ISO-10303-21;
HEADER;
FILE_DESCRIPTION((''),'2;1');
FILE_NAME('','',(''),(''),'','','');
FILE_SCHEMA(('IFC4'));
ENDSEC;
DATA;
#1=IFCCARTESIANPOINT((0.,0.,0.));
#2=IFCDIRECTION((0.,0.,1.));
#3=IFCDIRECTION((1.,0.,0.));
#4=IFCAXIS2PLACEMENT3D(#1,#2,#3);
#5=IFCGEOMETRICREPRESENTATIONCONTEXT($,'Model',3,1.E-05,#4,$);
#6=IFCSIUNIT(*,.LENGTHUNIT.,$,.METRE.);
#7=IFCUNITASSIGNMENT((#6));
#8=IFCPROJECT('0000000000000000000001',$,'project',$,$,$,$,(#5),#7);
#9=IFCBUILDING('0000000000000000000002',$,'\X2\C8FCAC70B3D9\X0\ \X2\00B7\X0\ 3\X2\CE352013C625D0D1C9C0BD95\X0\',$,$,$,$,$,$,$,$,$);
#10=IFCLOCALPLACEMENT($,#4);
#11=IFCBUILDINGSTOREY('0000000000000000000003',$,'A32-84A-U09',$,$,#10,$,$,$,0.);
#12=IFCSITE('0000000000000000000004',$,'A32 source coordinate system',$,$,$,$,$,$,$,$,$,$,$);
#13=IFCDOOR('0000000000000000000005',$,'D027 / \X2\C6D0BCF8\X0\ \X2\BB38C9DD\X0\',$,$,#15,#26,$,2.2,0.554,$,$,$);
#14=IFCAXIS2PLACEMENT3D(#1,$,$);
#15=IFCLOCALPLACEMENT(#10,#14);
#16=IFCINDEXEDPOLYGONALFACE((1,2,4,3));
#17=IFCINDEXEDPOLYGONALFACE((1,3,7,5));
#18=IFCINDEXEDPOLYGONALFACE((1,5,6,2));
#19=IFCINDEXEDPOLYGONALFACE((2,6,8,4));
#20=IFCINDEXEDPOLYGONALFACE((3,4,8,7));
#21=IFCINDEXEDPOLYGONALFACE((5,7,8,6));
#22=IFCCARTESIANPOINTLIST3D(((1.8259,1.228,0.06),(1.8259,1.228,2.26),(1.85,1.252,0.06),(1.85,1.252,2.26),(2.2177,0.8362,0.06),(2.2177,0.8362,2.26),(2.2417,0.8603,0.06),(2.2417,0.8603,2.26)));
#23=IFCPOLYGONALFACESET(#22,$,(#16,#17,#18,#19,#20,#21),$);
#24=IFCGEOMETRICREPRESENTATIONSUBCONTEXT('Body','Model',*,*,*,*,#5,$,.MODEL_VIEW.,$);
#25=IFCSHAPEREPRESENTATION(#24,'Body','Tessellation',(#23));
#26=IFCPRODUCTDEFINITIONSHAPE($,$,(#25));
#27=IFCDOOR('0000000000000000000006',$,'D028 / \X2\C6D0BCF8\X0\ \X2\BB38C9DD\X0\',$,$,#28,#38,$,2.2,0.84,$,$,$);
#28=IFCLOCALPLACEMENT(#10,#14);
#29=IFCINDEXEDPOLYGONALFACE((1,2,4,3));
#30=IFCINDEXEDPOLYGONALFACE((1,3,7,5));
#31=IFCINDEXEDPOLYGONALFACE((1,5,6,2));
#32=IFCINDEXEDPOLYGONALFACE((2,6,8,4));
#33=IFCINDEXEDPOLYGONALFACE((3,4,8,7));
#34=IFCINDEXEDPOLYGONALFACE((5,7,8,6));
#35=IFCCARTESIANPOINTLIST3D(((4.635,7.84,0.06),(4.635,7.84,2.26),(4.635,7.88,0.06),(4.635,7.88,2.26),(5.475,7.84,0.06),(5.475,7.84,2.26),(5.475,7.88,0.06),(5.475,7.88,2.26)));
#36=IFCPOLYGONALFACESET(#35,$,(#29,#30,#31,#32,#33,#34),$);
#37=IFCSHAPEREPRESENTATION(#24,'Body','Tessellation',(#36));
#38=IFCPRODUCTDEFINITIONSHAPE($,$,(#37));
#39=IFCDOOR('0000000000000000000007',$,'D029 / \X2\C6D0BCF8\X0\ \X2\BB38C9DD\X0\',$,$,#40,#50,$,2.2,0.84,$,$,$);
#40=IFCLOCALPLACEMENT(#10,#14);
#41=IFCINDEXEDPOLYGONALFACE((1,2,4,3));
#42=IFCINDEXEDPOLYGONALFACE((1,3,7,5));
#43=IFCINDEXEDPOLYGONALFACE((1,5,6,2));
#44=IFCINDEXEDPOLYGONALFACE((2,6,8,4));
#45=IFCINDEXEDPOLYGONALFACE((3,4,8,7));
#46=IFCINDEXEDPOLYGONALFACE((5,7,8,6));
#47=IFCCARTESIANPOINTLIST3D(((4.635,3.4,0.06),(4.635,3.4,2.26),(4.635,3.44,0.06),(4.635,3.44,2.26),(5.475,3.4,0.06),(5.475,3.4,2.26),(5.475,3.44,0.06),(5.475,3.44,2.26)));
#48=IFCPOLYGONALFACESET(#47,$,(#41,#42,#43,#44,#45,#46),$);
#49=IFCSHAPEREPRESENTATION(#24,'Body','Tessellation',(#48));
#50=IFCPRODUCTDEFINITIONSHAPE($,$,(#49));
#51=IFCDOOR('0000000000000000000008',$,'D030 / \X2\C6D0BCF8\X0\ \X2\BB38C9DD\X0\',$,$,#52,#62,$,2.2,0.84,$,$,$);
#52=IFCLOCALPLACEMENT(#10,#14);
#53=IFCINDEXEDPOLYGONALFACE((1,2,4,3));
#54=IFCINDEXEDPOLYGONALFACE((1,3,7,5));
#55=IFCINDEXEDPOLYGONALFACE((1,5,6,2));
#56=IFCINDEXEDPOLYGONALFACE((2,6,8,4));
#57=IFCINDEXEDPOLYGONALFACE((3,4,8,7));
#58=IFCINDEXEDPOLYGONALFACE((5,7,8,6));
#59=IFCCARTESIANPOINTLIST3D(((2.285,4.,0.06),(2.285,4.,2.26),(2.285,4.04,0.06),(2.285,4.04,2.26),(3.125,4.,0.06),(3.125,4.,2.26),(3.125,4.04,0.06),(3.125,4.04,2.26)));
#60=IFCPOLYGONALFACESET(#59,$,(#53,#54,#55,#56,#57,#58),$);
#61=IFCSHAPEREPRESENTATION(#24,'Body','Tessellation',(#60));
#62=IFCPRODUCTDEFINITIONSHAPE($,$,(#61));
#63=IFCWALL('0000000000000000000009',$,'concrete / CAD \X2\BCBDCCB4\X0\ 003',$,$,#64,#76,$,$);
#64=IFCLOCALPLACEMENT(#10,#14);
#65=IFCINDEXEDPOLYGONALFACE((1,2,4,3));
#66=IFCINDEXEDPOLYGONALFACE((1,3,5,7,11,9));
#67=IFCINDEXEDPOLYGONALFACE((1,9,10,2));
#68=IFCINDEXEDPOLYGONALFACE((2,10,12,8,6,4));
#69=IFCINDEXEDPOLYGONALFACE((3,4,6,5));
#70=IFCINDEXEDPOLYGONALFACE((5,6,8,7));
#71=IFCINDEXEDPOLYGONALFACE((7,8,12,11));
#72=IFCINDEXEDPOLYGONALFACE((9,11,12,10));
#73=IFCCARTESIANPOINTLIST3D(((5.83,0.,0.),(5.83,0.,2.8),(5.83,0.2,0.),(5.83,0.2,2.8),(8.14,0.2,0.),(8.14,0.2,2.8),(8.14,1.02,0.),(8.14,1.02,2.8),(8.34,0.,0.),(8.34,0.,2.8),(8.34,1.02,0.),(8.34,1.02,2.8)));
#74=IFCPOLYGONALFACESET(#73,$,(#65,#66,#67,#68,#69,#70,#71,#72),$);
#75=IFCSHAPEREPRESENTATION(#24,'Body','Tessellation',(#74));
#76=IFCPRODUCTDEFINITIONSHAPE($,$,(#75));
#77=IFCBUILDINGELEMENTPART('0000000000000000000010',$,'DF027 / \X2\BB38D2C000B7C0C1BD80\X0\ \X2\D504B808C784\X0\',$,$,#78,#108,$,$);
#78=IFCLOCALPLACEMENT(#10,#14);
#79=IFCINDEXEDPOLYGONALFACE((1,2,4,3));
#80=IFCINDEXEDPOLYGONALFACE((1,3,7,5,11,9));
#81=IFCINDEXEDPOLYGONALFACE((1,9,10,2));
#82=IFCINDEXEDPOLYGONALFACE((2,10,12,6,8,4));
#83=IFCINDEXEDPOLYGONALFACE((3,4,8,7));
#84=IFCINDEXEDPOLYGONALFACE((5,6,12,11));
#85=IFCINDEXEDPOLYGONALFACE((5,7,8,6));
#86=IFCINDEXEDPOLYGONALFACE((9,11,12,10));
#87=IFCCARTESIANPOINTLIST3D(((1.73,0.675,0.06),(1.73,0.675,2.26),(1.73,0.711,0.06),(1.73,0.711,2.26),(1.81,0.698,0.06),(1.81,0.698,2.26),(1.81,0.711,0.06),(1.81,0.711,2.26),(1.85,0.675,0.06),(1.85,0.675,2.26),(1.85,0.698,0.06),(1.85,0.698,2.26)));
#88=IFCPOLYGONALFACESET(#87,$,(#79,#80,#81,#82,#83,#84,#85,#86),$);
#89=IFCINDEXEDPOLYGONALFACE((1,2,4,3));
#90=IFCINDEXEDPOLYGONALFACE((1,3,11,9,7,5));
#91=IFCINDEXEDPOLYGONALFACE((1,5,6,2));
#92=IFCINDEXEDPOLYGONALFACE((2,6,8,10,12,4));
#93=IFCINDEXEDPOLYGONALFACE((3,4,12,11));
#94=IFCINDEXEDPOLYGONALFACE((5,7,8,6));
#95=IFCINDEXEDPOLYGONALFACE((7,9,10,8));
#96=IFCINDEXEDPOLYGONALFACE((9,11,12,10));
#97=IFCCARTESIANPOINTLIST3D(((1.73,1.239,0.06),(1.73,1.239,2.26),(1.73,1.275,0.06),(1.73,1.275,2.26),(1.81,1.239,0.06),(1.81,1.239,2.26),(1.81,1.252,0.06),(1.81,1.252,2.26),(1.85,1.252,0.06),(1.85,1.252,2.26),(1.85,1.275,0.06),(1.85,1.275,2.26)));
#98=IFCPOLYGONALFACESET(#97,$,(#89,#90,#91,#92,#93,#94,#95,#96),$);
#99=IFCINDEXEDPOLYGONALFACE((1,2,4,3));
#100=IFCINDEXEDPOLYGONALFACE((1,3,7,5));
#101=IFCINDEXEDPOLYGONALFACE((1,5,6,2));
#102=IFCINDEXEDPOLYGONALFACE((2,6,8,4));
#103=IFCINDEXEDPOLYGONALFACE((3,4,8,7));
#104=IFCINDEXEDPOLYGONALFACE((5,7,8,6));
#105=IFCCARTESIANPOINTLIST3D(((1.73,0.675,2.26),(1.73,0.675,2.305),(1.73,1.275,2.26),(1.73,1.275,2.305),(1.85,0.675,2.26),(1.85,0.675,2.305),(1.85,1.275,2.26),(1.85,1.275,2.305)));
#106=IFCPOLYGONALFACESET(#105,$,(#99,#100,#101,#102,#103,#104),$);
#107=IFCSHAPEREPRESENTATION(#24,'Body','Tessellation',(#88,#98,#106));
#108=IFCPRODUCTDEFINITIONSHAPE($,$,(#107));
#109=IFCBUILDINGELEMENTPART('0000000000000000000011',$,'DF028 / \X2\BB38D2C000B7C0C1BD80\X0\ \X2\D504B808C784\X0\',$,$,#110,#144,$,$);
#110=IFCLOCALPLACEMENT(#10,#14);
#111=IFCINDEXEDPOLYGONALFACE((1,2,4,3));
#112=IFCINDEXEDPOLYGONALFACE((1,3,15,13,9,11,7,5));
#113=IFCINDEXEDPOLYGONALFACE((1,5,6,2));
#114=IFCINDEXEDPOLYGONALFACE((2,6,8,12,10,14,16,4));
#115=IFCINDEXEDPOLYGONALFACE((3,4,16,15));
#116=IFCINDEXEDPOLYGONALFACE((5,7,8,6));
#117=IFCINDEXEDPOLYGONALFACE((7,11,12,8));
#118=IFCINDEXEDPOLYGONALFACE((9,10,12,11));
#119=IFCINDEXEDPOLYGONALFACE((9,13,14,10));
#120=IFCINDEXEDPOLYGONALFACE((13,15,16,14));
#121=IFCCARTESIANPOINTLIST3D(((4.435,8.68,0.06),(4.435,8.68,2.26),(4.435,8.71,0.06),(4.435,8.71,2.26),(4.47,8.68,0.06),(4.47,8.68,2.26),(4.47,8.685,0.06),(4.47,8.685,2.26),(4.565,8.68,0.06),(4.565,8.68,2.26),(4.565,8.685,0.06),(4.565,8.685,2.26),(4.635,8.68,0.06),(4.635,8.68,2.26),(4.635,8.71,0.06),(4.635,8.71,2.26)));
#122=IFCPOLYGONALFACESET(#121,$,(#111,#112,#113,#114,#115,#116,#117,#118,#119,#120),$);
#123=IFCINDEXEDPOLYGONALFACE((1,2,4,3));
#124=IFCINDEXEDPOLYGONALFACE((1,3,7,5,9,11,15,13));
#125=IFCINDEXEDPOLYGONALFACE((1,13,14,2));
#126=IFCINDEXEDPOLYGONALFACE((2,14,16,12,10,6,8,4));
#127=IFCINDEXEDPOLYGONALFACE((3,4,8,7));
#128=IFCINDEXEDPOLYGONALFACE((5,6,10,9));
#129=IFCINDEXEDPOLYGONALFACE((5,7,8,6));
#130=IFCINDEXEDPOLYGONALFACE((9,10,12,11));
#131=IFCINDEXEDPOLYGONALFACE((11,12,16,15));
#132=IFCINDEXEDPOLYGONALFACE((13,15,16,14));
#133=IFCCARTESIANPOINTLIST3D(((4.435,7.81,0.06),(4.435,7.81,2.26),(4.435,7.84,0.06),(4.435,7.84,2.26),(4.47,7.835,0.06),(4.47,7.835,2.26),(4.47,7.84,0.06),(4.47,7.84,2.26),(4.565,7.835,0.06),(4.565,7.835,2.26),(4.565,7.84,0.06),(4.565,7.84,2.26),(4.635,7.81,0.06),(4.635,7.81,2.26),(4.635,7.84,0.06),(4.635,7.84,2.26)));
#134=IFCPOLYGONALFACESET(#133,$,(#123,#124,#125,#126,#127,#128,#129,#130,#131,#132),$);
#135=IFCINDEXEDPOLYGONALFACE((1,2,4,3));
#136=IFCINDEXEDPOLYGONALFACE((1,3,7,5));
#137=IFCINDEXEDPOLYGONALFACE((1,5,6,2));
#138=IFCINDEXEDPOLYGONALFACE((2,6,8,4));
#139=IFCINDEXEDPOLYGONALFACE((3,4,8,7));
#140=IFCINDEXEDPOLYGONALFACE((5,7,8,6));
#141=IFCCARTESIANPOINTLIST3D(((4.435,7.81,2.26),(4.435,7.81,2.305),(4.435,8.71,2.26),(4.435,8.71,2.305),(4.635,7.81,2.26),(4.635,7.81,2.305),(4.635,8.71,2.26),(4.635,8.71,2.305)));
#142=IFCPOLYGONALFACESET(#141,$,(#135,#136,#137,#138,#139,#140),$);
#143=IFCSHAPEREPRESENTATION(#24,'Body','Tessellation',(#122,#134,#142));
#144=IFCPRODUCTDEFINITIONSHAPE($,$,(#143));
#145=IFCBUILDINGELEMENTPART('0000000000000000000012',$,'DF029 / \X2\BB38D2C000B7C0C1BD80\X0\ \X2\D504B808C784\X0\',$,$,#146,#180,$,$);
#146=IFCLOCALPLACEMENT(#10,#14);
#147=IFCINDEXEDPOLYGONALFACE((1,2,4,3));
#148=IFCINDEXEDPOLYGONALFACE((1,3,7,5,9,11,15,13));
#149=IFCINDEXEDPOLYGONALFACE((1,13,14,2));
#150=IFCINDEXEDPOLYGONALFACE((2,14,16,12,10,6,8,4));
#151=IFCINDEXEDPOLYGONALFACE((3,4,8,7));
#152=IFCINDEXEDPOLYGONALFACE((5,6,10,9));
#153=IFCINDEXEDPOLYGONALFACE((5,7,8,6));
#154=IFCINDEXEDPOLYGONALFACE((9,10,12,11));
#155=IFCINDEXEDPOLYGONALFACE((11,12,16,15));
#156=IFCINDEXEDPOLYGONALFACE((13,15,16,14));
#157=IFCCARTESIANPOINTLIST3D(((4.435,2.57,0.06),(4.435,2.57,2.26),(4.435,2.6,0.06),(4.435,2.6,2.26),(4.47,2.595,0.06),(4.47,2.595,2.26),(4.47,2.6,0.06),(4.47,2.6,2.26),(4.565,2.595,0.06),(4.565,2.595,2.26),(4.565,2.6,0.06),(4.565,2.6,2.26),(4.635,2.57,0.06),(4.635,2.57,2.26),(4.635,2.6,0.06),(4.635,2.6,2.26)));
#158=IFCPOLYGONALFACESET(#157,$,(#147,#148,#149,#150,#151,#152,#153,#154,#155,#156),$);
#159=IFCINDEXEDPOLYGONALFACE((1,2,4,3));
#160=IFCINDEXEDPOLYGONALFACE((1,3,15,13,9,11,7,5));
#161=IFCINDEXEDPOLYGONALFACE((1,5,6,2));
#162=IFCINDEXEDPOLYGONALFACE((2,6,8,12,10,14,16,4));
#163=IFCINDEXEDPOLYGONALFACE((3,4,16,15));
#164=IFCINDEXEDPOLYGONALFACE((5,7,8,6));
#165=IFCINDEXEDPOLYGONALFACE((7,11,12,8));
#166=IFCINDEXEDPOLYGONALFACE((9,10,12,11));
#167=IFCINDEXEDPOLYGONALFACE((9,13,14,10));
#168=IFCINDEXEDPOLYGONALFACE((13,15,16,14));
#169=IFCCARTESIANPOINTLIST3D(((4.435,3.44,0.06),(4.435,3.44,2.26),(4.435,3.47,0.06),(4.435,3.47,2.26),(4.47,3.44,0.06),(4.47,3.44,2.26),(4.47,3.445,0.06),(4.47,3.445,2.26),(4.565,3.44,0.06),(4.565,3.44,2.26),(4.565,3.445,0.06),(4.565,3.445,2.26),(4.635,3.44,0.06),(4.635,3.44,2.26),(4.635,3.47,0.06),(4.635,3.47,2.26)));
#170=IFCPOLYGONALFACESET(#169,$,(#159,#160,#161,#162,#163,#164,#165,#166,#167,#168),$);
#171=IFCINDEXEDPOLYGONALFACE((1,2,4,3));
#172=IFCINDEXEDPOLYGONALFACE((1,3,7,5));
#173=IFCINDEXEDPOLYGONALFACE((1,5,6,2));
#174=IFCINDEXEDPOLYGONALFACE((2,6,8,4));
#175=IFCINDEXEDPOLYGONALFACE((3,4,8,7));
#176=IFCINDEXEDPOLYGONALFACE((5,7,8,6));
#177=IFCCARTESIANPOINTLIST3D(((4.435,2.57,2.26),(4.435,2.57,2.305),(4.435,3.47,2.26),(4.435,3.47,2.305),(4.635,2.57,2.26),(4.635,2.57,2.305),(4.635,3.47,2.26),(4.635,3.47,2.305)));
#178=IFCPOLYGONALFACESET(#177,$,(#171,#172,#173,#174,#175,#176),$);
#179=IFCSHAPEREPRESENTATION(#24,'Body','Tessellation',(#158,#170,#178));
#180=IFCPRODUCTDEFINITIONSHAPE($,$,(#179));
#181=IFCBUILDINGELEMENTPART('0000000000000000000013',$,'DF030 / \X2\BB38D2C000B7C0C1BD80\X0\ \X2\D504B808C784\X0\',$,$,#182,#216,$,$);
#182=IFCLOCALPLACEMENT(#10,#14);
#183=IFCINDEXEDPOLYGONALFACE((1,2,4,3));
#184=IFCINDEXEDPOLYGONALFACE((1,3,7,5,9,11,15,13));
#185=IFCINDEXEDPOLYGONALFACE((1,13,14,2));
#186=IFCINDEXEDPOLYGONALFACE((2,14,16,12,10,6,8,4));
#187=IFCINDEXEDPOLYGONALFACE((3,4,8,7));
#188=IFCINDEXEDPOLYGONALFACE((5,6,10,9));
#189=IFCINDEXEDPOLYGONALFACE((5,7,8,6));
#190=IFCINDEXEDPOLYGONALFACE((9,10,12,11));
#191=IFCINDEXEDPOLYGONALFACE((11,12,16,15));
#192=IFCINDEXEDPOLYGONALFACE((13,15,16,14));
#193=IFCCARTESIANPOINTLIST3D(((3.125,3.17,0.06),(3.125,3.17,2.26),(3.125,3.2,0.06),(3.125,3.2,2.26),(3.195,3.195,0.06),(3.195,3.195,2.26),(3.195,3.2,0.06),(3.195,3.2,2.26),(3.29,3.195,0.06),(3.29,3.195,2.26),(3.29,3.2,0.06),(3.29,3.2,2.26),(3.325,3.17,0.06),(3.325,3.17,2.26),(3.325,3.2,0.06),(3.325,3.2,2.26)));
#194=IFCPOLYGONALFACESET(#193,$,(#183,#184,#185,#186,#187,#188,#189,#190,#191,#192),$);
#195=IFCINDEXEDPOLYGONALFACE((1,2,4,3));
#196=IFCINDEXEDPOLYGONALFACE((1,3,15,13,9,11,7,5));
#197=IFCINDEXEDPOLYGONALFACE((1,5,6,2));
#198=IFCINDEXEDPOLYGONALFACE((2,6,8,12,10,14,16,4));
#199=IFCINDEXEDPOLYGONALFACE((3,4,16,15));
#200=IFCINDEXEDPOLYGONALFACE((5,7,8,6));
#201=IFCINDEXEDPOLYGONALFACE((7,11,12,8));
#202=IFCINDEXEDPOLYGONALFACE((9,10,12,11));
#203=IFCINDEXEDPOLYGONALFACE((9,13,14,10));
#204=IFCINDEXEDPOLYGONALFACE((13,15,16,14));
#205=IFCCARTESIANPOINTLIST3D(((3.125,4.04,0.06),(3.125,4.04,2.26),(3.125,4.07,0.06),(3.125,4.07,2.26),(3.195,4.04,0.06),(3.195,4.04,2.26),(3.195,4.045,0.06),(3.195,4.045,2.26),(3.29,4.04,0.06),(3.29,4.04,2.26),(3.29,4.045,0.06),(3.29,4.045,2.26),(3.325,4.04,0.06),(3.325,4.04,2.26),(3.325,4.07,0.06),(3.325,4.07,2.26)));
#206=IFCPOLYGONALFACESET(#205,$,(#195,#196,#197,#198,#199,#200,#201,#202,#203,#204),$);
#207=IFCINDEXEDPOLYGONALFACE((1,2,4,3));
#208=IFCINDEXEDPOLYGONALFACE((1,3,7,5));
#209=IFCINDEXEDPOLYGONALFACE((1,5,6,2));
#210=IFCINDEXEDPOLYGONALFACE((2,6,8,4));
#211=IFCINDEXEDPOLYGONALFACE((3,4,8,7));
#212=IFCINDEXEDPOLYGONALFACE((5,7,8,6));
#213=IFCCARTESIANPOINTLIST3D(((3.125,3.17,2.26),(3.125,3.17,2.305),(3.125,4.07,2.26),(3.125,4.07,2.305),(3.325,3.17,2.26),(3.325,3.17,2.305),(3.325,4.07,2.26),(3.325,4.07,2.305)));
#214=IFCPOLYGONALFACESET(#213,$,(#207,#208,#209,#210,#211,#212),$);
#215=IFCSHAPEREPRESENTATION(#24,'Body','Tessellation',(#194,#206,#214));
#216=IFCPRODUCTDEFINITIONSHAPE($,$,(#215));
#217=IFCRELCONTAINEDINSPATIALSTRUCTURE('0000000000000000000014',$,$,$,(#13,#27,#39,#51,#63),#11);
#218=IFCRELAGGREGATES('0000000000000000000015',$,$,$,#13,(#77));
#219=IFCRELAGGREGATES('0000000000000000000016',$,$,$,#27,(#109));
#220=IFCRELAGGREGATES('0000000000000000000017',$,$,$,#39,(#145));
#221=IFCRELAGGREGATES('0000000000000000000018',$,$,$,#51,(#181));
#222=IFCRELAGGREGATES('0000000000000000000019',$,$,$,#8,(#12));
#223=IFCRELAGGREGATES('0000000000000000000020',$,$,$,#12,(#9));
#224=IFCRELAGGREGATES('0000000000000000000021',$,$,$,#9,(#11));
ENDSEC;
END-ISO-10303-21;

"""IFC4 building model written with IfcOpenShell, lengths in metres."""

from ifc_helpers import new_model, si_unit, frame, origin, origin_with_axes, place, context, subcontext, project, spatial, polyline, outline, extrude, element, aggregate, save


model = new_model("IFC4")

# Units and contexts
model_context = context("Model", 3, precision=1e-05, world=origin_with_axes())
body_context = subcontext(model_context, "Body", "Model", "MODEL_VIEW")
ifc_project = project(units=[si_unit("LENGTHUNIT", "METRE")], contexts=[model_context])

# Site, building, storey
storey_placement = place(None, origin_with_axes())
site = spatial("IfcSite", under=ifc_project, Name="A32 source coordinate system")
building = spatial("IfcBuilding", under=site, Name="주거동 · 3층–옥탑지붕")
storey = spatial("IfcBuildingStorey", under=building, at=storey_placement, Name="A32-84A-U09", Elevation=0.0)

# Doors
door_1_placement = place(storey_placement, origin_with_axes())
door_1 = element("IfcDoor", 1, at=door_1_placement, inside=storey, Name="D027 / 원본 문짝", OverallHeight=2.2, OverallWidth=0.554, context=body_context, shape_type="SweptSolid", body=[
    extrude(outline(polyline([(1.85, 1.252), (2.2417, 0.8603), (2.2177, 0.8362), (1.8259, 1.228), (1.85, 1.252)])), frame((0.0, 0.0, 0.06)), (0.0, 0.0, 1.0), 2.2),
])
door_2_placement = place(storey_placement, origin_with_axes())
door_2 = element("IfcDoor", 2, at=door_2_placement, inside=storey, Name="D028 / 원본 문짝", OverallHeight=2.2, OverallWidth=0.84, context=body_context, shape_type="SweptSolid", body=[
    extrude(outline(polyline([(5.475, 7.88), (5.475, 7.84), (4.635, 7.84), (4.635, 7.88), (5.475, 7.88)])), frame((0.0, 0.0, 0.06)), (0.0, 0.0, 1.0), 2.2),
])
door_3_placement = place(storey_placement, origin_with_axes())
door_3 = element("IfcDoor", 3, at=door_3_placement, inside=storey, Name="D029 / 원본 문짝", OverallHeight=2.2, OverallWidth=0.84, context=body_context, shape_type="SweptSolid", body=[
    extrude(outline(polyline([(4.635, 3.44), (5.475, 3.44), (5.475, 3.4), (4.635, 3.4), (4.635, 3.44)])), frame((0.0, 0.0, 0.06)), (0.0, 0.0, 1.0), 2.2),
])
door_4_placement = place(storey_placement, origin_with_axes())
door_4 = element("IfcDoor", 4, at=door_4_placement, inside=storey, Name="D030 / 원본 문짝", OverallHeight=2.2, OverallWidth=0.84, context=body_context, shape_type="SweptSolid", body=[
    extrude(outline(polyline([(2.285, 4.0), (2.285, 4.04), (3.125, 4.04), (3.125, 4.0), (2.285, 4.0)])), frame((0.0, 0.0, 0.06)), (0.0, 0.0, 1.0), 2.2),
])

# Wall
wall_1_placement = place(storey_placement, origin_with_axes())
element("IfcWall", 5, at=wall_1_placement, inside=storey, Name="concrete / CAD 벽체 003", context=body_context, shape_type="SweptSolid", body=[
    extrude(outline(polyline([(5.83, 0.2), (8.14, 0.2), (8.14, 1.02), (8.34, 1.02), (8.34, 0.0), (5.83, 0.0), (5.83, 0.2)])), origin(), (0.0, 0.0, 1.0), 2.8),
])

# Building element parts
building_element_part_1_placement = place(door_1_placement, origin_with_axes())
building_element_part_1 = element("IfcBuildingElementPart", 6, at=building_element_part_1_placement, Name="DF027 / 문틀·상부 프레임", context=body_context, shape_type="SweptSolid", body=[
    extrude(outline(polyline([(1.73, 0.711), (1.81, 0.711), (1.81, 0.698), (1.85, 0.698), (1.85, 0.675), (1.73, 0.675), (1.73, 0.711)])), frame((0.0, 0.0, 0.06)), (0.0, 0.0, 1.0), 2.2),
    extrude(outline(polyline([(1.85, 1.275), (1.85, 1.252), (1.81, 1.252), (1.81, 1.239), (1.73, 1.239), (1.73, 1.275), (1.85, 1.275)])), frame((0.0, 0.0, 0.06)), (0.0, 0.0, 1.0), 2.2),
    extrude(outline(polyline([(1.73, 0.675), (1.73, 1.275), (1.85, 1.275), (1.85, 0.675), (1.73, 0.675)])), frame((0.0, 0.0, 2.26)), (0.0, 0.0, 1.0), 0.045),
])
aggregate(door_1, [building_element_part_1])
building_element_part_2_placement = place(door_2_placement, origin_with_axes())
building_element_part_2 = element("IfcBuildingElementPart", 7, at=building_element_part_2_placement, Name="DF028 / 문틀·상부 프레임", context=body_context, shape_type="SweptSolid", body=[
    extrude(outline(polyline([(4.635, 8.68), (4.565, 8.68), (4.565, 8.685), (4.47, 8.685), (4.47, 8.68), (4.435, 8.68), (4.435, 8.71), (4.635, 8.71), (4.635, 8.68)])), frame((0.0, 0.0, 0.06)), (0.0, 0.0, 1.0), 2.2),
    extrude(outline(polyline([(4.435, 7.81), (4.435, 7.84), (4.47, 7.84), (4.47, 7.835), (4.565, 7.835), (4.565, 7.84), (4.635, 7.84), (4.635, 7.81), (4.435, 7.81)])), frame((0.0, 0.0, 0.06)), (0.0, 0.0, 1.0), 2.2),
    extrude(outline(polyline([(4.435, 7.81), (4.435, 8.71), (4.635, 8.71), (4.635, 7.81), (4.435, 7.81)])), frame((0.0, 0.0, 2.26)), (0.0, 0.0, 1.0), 0.045),
])
aggregate(door_2, [building_element_part_2])
building_element_part_3_placement = place(door_3_placement, origin_with_axes())
building_element_part_3 = element("IfcBuildingElementPart", 8, at=building_element_part_3_placement, Name="DF029 / 문틀·상부 프레임", context=body_context, shape_type="SweptSolid", body=[
    extrude(outline(polyline([(4.435, 2.57), (4.435, 2.6), (4.47, 2.6), (4.47, 2.595), (4.565, 2.595), (4.565, 2.6), (4.635, 2.6), (4.635, 2.57), (4.435, 2.57)])), frame((0.0, 0.0, 0.06)), (0.0, 0.0, 1.0), 2.2),
    extrude(outline(polyline([(4.635, 3.44), (4.565, 3.44), (4.565, 3.445), (4.47, 3.445), (4.47, 3.44), (4.435, 3.44), (4.435, 3.47), (4.635, 3.47), (4.635, 3.44)])), frame((0.0, 0.0, 0.06)), (0.0, 0.0, 1.0), 2.2),
    extrude(outline(polyline([(4.435, 2.57), (4.435, 3.47), (4.635, 3.47), (4.635, 2.57), (4.435, 2.57)])), frame((0.0, 0.0, 2.26)), (0.0, 0.0, 1.0), 0.045),
])
aggregate(door_3, [building_element_part_3])
building_element_part_4_placement = place(door_4_placement, origin_with_axes())
building_element_part_4 = element("IfcBuildingElementPart", 9, at=building_element_part_4_placement, Name="DF030 / 문틀·상부 프레임", context=body_context, shape_type="SweptSolid", body=[
    extrude(outline(polyline([(3.125, 3.2), (3.195, 3.2), (3.195, 3.195), (3.29, 3.195), (3.29, 3.2), (3.325, 3.2), (3.325, 3.17), (3.125, 3.17), (3.125, 3.2)])), frame((0.0, 0.0, 0.06)), (0.0, 0.0, 1.0), 2.2),
    extrude(outline(polyline([(3.325, 4.07), (3.325, 4.04), (3.29, 4.04), (3.29, 4.045), (3.195, 4.045), (3.195, 4.04), (3.125, 4.04), (3.125, 4.07), (3.325, 4.07)])), frame((0.0, 0.0, 0.06)), (0.0, 0.0, 1.0), 2.2),
    extrude(outline(polyline([(3.125, 3.17), (3.125, 4.07), (3.325, 4.07), (3.325, 3.17), (3.125, 3.17)])), frame((0.0, 0.0, 2.26)), (0.0, 0.0, 1.0), 0.045),
])
aggregate(door_4, [building_element_part_4])

save(model, "model.ifc")
